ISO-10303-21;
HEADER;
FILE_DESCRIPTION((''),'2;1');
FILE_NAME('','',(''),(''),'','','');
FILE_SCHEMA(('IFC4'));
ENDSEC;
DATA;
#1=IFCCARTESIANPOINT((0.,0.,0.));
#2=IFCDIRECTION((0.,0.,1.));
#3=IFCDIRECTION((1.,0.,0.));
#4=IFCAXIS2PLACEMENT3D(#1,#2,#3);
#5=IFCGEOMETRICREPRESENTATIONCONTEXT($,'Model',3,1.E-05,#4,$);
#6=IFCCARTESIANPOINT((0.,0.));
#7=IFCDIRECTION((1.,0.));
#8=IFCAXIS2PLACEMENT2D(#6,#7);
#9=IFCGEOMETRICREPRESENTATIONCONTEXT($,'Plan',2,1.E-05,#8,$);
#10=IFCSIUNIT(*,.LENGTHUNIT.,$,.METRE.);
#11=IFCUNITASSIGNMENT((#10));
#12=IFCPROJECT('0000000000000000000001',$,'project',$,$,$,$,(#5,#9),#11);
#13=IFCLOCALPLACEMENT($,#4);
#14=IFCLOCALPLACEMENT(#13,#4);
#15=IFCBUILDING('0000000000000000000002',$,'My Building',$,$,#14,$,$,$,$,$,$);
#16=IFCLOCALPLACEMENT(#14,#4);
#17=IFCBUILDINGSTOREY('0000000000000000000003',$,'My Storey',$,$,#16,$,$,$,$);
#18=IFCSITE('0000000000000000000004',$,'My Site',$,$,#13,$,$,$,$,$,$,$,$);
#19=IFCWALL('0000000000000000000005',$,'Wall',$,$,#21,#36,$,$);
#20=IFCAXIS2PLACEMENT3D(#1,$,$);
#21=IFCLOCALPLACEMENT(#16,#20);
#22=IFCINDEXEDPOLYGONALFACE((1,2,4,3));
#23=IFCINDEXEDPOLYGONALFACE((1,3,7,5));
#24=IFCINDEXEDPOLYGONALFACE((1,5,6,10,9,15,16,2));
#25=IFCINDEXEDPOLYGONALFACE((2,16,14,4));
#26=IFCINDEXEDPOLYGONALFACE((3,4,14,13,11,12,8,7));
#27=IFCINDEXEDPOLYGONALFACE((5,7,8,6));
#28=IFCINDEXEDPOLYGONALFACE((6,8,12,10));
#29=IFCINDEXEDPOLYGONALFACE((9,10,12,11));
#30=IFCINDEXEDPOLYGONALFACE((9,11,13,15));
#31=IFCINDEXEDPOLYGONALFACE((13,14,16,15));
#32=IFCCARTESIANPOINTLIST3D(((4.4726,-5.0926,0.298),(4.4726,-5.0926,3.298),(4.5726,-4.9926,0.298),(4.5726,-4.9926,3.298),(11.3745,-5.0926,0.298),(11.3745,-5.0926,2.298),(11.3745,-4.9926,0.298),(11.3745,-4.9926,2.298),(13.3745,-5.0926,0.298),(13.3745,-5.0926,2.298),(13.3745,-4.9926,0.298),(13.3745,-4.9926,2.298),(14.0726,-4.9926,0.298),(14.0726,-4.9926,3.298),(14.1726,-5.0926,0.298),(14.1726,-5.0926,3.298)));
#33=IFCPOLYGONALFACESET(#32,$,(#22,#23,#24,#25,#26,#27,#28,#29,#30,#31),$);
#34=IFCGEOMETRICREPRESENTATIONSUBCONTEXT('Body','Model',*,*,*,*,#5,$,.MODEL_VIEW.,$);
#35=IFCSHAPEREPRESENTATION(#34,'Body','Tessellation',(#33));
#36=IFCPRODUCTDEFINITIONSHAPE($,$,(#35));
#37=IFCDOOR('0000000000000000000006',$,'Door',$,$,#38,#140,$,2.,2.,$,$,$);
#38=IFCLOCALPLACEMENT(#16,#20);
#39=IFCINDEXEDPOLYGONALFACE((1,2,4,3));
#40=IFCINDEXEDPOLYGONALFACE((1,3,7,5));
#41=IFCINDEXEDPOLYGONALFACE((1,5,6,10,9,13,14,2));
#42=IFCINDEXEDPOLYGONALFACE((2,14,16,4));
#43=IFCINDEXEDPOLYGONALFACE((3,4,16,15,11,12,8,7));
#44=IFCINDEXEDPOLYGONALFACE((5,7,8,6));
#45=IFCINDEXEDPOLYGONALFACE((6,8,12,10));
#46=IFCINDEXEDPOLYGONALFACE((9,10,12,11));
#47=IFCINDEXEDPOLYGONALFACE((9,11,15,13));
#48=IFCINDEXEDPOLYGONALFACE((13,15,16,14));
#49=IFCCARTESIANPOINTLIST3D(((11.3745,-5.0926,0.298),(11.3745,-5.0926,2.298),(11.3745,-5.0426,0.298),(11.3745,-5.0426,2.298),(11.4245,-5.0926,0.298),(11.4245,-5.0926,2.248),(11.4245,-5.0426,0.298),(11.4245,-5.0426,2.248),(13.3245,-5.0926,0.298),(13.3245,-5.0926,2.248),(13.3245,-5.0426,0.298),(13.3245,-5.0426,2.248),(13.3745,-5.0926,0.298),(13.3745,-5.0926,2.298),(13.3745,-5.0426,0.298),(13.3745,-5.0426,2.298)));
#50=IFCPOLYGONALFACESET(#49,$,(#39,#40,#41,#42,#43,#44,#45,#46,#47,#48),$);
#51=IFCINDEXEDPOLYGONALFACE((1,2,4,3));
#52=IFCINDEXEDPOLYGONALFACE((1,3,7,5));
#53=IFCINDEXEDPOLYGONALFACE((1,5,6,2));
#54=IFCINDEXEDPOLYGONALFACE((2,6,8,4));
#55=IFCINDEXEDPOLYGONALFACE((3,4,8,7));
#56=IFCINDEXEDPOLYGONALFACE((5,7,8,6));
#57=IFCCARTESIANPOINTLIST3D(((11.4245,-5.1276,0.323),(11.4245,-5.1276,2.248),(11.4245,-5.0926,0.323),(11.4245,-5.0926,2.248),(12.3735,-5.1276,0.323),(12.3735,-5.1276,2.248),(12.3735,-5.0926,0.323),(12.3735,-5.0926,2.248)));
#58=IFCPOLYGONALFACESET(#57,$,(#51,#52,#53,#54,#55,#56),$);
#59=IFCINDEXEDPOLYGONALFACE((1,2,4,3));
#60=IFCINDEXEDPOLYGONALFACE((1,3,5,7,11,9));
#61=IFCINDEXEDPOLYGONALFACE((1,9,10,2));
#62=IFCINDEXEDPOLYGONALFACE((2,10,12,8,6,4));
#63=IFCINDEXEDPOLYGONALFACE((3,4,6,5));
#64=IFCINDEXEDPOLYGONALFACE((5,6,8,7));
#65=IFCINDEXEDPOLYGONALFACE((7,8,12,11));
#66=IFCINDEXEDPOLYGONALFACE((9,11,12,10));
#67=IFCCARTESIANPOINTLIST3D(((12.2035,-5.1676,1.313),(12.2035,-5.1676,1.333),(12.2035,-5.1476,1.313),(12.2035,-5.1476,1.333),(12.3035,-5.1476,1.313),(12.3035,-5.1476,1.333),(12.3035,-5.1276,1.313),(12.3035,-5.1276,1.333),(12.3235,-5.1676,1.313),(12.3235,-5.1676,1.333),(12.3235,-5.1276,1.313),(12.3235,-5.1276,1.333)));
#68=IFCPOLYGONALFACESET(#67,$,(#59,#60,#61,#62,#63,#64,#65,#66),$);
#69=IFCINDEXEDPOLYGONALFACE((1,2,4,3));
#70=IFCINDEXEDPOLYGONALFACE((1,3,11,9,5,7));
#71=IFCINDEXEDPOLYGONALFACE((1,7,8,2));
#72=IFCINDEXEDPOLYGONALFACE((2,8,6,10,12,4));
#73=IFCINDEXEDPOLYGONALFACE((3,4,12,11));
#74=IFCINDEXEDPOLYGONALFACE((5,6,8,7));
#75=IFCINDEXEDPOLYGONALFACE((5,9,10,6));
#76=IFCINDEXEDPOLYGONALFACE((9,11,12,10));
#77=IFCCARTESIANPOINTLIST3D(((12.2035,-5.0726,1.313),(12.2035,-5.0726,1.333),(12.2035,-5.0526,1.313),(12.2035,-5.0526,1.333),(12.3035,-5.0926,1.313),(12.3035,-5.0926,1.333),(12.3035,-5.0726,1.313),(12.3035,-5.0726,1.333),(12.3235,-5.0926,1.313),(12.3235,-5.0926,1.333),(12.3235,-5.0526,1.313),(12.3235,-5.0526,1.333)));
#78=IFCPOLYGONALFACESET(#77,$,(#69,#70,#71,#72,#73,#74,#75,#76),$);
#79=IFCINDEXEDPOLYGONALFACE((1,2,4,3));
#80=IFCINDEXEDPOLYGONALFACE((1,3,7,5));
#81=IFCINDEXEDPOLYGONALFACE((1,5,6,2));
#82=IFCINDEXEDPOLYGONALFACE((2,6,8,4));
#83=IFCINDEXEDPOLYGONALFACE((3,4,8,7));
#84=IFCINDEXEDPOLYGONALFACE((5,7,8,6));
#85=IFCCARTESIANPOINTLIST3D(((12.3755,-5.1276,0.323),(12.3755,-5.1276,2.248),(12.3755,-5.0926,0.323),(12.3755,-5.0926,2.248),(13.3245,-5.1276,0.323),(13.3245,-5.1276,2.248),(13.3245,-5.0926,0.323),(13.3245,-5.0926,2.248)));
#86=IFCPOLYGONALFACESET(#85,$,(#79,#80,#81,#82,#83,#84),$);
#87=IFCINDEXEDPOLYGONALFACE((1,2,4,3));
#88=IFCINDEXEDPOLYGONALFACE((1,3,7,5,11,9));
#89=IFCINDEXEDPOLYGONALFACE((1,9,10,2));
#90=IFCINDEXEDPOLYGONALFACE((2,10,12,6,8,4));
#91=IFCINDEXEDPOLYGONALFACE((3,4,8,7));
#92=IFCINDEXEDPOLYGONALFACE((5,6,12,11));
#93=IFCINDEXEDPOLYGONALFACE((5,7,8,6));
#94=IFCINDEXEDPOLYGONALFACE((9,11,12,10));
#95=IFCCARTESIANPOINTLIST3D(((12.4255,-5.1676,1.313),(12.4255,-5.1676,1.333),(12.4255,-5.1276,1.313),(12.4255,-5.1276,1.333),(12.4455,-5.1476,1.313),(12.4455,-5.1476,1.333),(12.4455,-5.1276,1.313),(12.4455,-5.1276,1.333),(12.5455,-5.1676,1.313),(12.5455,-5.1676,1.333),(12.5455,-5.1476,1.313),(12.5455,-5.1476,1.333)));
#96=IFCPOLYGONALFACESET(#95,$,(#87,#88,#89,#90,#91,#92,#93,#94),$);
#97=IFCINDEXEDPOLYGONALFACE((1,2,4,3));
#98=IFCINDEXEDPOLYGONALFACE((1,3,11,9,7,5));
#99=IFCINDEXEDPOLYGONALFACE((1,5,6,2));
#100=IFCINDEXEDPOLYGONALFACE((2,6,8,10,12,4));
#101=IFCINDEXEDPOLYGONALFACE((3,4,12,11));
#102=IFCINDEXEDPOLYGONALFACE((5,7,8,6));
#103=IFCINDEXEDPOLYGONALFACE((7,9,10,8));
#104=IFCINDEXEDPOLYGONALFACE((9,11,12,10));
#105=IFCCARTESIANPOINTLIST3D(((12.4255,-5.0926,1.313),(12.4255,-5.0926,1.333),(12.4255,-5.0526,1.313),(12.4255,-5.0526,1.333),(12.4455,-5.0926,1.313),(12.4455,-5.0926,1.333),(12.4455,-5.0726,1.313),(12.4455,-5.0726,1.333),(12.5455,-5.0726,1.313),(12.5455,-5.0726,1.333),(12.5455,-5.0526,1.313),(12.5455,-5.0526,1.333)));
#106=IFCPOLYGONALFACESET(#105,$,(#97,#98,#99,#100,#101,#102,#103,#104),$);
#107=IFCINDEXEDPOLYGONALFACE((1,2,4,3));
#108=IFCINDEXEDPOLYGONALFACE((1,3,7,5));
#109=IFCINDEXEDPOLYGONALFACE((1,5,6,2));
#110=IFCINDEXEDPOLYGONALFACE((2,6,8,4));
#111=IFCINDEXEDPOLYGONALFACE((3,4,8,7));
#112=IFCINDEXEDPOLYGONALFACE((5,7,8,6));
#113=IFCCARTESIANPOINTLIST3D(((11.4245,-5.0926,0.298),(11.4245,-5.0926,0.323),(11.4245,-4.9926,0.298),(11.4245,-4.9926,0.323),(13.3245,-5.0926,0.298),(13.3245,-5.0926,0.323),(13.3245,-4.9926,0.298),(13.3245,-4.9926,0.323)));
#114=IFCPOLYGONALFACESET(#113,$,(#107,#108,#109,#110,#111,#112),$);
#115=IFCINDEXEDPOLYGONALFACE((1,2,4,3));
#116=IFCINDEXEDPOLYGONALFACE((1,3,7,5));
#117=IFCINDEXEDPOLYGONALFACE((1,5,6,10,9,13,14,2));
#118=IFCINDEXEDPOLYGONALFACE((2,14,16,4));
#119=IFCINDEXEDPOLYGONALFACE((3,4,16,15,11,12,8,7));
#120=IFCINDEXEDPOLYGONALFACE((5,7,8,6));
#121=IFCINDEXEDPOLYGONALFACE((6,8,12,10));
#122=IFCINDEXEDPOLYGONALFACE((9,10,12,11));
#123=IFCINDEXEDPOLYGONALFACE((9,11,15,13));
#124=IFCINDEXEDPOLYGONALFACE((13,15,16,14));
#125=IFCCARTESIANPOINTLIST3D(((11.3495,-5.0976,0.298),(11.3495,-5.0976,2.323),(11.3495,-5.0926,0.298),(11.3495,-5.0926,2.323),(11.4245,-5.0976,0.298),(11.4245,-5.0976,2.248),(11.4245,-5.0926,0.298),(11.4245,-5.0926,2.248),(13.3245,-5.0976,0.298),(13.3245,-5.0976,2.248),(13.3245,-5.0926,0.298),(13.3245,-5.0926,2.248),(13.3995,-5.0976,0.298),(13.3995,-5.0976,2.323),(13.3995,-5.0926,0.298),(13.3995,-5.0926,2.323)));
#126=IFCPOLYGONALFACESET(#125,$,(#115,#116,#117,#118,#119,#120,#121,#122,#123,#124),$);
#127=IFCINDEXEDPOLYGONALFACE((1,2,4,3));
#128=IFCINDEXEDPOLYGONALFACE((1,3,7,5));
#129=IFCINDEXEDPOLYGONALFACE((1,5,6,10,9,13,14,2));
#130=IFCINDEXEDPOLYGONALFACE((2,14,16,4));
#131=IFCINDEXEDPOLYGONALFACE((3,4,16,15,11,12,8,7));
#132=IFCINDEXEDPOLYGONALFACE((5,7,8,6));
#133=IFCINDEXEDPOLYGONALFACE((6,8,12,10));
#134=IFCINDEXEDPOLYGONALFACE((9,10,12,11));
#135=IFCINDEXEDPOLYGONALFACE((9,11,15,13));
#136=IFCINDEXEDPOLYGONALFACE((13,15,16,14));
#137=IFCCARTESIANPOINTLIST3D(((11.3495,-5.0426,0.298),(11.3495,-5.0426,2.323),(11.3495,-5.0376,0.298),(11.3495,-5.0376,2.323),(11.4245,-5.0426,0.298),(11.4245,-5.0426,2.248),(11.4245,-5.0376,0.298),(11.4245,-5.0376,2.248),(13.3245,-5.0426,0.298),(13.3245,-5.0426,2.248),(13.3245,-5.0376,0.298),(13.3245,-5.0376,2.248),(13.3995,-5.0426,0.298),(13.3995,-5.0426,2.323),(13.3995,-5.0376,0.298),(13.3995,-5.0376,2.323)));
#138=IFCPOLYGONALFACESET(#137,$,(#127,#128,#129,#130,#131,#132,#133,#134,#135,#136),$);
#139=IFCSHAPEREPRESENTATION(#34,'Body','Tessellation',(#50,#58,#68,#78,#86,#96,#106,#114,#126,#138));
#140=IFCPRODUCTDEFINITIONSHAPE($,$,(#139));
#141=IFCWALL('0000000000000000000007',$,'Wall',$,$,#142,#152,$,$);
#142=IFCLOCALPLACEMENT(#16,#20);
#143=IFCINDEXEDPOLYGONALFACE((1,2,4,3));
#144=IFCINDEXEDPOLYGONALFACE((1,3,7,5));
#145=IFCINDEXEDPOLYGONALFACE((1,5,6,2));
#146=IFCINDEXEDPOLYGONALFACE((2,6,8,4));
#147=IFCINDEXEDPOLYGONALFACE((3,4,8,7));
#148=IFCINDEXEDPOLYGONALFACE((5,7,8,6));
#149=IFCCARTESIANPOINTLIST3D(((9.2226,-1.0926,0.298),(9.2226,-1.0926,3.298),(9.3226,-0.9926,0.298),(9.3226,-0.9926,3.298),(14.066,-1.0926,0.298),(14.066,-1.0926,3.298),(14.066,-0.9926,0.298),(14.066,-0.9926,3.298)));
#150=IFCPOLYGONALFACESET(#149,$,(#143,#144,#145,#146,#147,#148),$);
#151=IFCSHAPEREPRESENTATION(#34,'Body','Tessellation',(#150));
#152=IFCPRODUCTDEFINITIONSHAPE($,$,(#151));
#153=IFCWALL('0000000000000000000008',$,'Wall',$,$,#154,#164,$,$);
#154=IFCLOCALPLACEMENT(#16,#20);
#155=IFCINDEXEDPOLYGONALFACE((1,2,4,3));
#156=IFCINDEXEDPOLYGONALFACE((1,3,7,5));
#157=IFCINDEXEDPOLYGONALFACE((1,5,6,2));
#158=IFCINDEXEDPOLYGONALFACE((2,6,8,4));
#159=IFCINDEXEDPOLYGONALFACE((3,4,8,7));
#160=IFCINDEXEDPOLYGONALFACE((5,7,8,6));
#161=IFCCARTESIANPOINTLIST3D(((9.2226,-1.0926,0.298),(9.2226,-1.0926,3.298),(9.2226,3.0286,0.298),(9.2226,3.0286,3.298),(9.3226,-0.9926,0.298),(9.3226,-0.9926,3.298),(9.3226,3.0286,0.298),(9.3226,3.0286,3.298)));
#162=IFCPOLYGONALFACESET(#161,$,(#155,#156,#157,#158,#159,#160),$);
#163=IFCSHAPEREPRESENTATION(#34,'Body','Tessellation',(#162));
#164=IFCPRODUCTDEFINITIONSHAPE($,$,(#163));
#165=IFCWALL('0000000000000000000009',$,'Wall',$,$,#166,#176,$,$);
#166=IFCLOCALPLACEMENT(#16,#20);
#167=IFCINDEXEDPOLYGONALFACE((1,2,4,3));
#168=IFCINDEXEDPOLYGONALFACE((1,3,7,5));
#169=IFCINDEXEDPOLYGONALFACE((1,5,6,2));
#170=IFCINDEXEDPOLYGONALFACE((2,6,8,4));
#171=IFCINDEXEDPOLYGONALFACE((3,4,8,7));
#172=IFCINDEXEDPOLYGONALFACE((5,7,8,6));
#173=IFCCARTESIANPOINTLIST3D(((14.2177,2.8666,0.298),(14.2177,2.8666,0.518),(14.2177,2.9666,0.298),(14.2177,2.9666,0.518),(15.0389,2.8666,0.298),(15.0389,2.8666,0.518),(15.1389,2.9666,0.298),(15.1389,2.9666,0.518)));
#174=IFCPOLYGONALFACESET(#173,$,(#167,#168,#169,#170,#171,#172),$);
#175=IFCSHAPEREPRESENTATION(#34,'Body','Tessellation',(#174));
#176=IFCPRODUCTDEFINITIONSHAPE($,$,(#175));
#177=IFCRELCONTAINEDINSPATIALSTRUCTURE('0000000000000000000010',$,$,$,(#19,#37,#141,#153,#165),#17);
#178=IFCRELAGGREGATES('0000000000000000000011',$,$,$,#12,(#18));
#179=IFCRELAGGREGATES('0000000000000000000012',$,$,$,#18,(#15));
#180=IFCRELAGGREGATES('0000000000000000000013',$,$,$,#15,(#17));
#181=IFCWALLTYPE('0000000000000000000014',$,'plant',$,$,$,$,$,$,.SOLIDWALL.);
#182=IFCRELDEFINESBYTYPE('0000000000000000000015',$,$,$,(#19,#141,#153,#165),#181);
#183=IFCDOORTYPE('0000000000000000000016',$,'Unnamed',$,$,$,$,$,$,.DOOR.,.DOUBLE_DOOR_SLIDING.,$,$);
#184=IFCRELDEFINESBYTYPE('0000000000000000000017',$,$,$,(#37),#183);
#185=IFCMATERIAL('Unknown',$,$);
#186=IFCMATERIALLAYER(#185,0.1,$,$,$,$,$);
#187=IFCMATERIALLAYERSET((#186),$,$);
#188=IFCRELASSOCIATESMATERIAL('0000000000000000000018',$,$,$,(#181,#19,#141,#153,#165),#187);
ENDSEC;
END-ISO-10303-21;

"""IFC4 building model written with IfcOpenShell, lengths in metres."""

from ifc_helpers import new_model, entity, si_unit, frame, origin_with_axes, origin_2d_with_axis, place, context, subcontext, project, spatial, line, indexed_curve, outline, extrude, shape, source, transform, mapped, material, layer, layer_set, layer_usage, type_object, type_shapes, element, fill, save


model = new_model("IFC4")

# Units and contexts
model_context = context("Model", 3, precision=1e-05, world=origin_with_axes())
plan_context = context("Plan", 2, precision=1e-05, world=origin_2d_with_axis())
body_context_1 = subcontext(model_context, "Body", "Model", "MODEL_VIEW")
body_context_2 = subcontext(plan_context, "Body", "Plan", "PLAN_VIEW")
ifc_project = project(units=[si_unit("LENGTHUNIT", "METRE")], contexts=[model_context, plan_context])

# Site, building, storey
site_placement = place(None, origin_with_axes())
site = spatial("IfcSite", under=ifc_project, at=site_placement, Name="My Site")
building_placement = place(site_placement, origin_with_axes())
building = spatial("IfcBuilding", under=site, at=building_placement, Name="My Building")
storey_placement = place(building_placement, origin_with_axes())
storey = spatial("IfcBuildingStorey", under=building, at=storey_placement, Name="My Storey")

# Shared definitions
ifc_material = material(Name="Unknown")

# Shared definitions
ifc_layer_1 = layer(ifc_material, 0.1)
ifc_layer_set_1 = layer_set([ifc_layer_1])
wall_type = type_object("IfcWallType", Name="plant", PredefinedType="SOLIDWALL", material=ifc_layer_set_1)

# Wall, opening, door
ifc_layer_usage_1 = layer_usage(ifc_layer_set_1, "AXIS2", "POSITIVE", 0.0)
wall_1_placement = place(storey_placement, frame((14.0726, -4.9926, 0.298), z_axis=(0.0, 0.0, 1.0), x_axis=(-1.0, 0.0, 0.0)))
wall_1 = element("IfcWall", 1, at=wall_1_placement, inside=storey, type_object=wall_type, material=ifc_layer_usage_1, Name="Wall", context=body_context_1, shape_type="SweptSolid", body=[
    extrude(outline(indexed_curve([(0.0, 0.0), (-0.1, 0.1), (9.6, 0.1), (9.5, 0.0)], segments=[line(1, 2, 3, 4, 1)])), origin_with_axes(), (0.0, 0.0, 1.0), 3.0),
])
shared_shape_1 = source(origin_with_axes(), body_context_1, "Body", "SweptSolid", [
    extrude(outline(indexed_curve([(0.0, 0.0), (2.0, 0.0), (2.0, 2.0), (0.0, 2.0)], segments=[line(1, 2, 3, 4, 1)])), frame((0.0, -0.6, 0.0), z_axis=(0.0, -1.0, 0.0), x_axis=(1.0, 0.0, 0.0)), (0.0, 0.0, -1.0), 1.2),
])
opening_placement = place(wall_1_placement, frame((2.6982, 0.1, 0.0), z_axis=(0.0, 0.0, 1.0), x_axis=(-1.0, 0.0, 0.0)))
opening = element("IfcOpeningElement", 2, at=opening_placement, cuts=wall_1, PredefinedType="OPENING", context=body_context_1, shape_type="MappedRepresentation", body=[
    mapped(shared_shape_1, transform((0.0, 0.0, 0.0), x_axis=(1.0, 0.0, 0.0), y_axis=(0.0, 1.0, 0.0), z_axis=(0.0, 0.0, 1.0), scale=1.0)),
])
door_type = type_object("IfcDoorType", Name="Unnamed", OperationType="DOUBLE_DOOR_SLIDING", PredefinedType="DOOR")
shared_shape_2 = source(origin_with_axes(), body_context_1, "Body", "SweptSolid", [
    extrude(outline(indexed_curve([(0.0, 0.0), (0.0, 2.0), (2.0, 2.0), (2.0, 0.0), (1.95, 0.0), (1.95, 1.95), (0.05, 1.95), (0.05, 0.0)], segments=[line(1, 2, 3, 4, 5, 6, 7, 8, 1)])), frame((0.0, 0.0, 0.0), z_axis=(0.0, -1.0, 0.0), x_axis=(1.0, 0.0, 0.0)), (0.0, 0.0, -1.0), 0.05),
    extrude(outline(indexed_curve([(0.0, 0.035), (0.949, 0.035), (0.949, 0.0), (0.0, 0.0), (0.0, 0.035)])), frame((0.05, -0.035, 0.025), z_axis=(0.0, 0.0, 1.0), x_axis=(1.0, 0.0, 0.0)), (0.0, 0.0, 1.0), 1.925),
    extrude(outline(indexed_curve([(0.0, 0.0), (0.0, -0.04), (-0.12, -0.04), (-0.12, -0.02), (-0.02, -0.02), (-0.02, 0.0)], segments=[line(1, 2, 3, 4, 5, 6, 1)])), frame((0.949, -0.035, 1.015), z_axis=(0.0, 0.0, 1.0), x_axis=(1.0, 0.0, 0.0)), (0.0, 0.0, 1.0), 0.02),
    extrude(outline(indexed_curve([(0.0, 0.0), (0.0, 0.04), (-0.12, 0.04), (-0.12, 0.02), (-0.02, 0.02), (-0.02, 0.0)], segments=[line(1, 2, 3, 4, 5, 6, 1)])), frame((0.949, 0.0, 1.015), z_axis=(0.0, 0.0, 1.0), x_axis=(1.0, 0.0, 0.0)), (0.0, 0.0, 1.0), 0.02),
    extrude(outline(indexed_curve([(0.0, 0.0), (-0.949, 0.0), (-0.949, 0.035), (0.0, 0.035)], segments=[line(1, 2, 3, 4, 1)])), frame((1.95, -0.035, 0.025), z_axis=(0.0, 0.0, 1.0), x_axis=(1.0, 0.0, 0.0)), (0.0, 0.0, 1.0), 1.925),
    extrude(outline(indexed_curve([(0.0, 0.0), (0.0, -0.04), (0.12, -0.04), (0.12, -0.02), (0.02, -0.02), (0.02, 0.0)], segments=[line(1, 2, 3, 4, 5, 6, 1)])), frame((1.051, -0.035, 1.015), z_axis=(0.0, 0.0, 1.0), x_axis=(1.0, 0.0, 0.0)), (0.0, 0.0, 1.0), 0.02),
    extrude(outline(indexed_curve([(0.0, 0.0), (0.0, 0.04), (0.12, 0.04), (0.12, 0.02), (0.02, 0.02), (0.02, 0.0)], segments=[line(1, 2, 3, 4, 5, 6, 1)])), frame((1.051, 0.0, 1.015), z_axis=(0.0, 0.0, 1.0), x_axis=(1.0, 0.0, 0.0)), (0.0, 0.0, 1.0), 0.02),
    extrude(outline(indexed_curve([(0.0, 0.0), (1.9, 0.0), (1.9, 0.1), (0.0, 0.1)], segments=[line(1, 2, 3, 4, 1)])), frame((0.05, 0.0, 0.0), z_axis=(0.0, 0.0, 1.0), x_axis=(1.0, 0.0, 0.0)), (0.0, 0.0, 1.0), 0.025),
    extrude(outline(indexed_curve([(0.0, 0.0), (0.0, 2.025), (2.05, 2.025), (2.05, 0.0), (1.975, 0.0), (1.975, 1.95), (0.075, 1.95), (0.075, 0.0)], segments=[line(1, 2, 3, 4, 5, 6, 7, 8, 1)])), frame((-0.025, -0.005, 0.0), z_axis=(0.0, -1.0, 0.0), x_axis=(1.0, 0.0, 0.0)), (0.0, 0.0, -1.0), 0.005),
    extrude(outline(indexed_curve([(0.0, 0.0), (0.0, 2.025), (2.05, 2.025), (2.05, 0.0), (1.975, 0.0), (1.975, 1.95), (0.075, 1.95), (0.075, 0.0)], segments=[line(1, 2, 3, 4, 5, 6, 7, 8, 1)])), frame((-0.025, 0.05, 0.0), z_axis=(0.0, -1.0, 0.0), x_axis=(1.0, 0.0, 0.0)), (0.0, 0.0, -1.0), 0.005),
])
shared_shape_3 = source(origin_with_axes(), body_context_2, "Body", "Curve2D", [
    entity("IfcIndexedPolyCurve", entity("IfcCartesianPointList2D", [[0.0, 0.0], [0.05, 0.0], [0.05, 0.05], [0.0, 0.05]]), [entity("IfcLineIndex", [1, 2, 3, 4, 1])]),
    entity("IfcIndexedPolyCurve", entity("IfcCartesianPointList2D", [[2.0, 0.0], [1.95, 0.0], [1.95, 0.05], [2.0, 0.05]]), [entity("IfcLineIndex", [1, 2, 3, 4, 1])]),
    entity("IfcIndexedPolyCurve", entity("IfcCartesianPointList2D", [[-0.425, -0.035], [0.525, -0.035], [0.525, 0.0], [-0.425, 0.0]]), [entity("IfcLineIndex", [1, 2, 3, 4, 1])]),
    entity("IfcIndexedPolyCurve", entity("IfcCartesianPointList2D", [[2.425, -0.035], [1.475, -0.035], [1.475, 0.0], [2.425, 0.0]]), [entity("IfcLineIndex", [1, 2, 3, 4, 1])]),
])
type_shapes(door_type, [shared_shape_2, shared_shape_3])
door_placement = place(opening_placement, frame((0.0, 0.0, 0.0), z_axis=(0.0, 0.0, 1.0), x_axis=(1.0, 0.0, 0.0)))
door = element("IfcDoor", 3, at=door_placement, inside=storey, type_object=door_type, Name="Door", OverallHeight=2.0, OverallWidth=2.0, shapes=[
    shape(body_context_1, "Body", "MappedRepresentation", [mapped(shared_shape_2, transform((0.0, 0.0, 0.0), x_axis=(1.0, 0.0, 0.0), y_axis=(0.0, 1.0, 0.0), z_axis=(0.0, 0.0, 1.0), scale=1.0))]),
    shape(body_context_2, "Body", "MappedRepresentation", [mapped(shared_shape_3, transform((0.0, 0.0, 0.0), x_axis=(1.0, 0.0, 0.0), y_axis=(0.0, 1.0, 0.0), z_axis=(0.0, 0.0, 1.0), scale=1.0))]),
])
fill(opening, door)

# Walls
ifc_layer_usage_2 = layer_usage(ifc_layer_set_1, "AXIS2", "POSITIVE", 0.0)
wall_2_placement = place(storey_placement, frame((14.066, -0.9926, 0.298), z_axis=(0.0, 0.0, 1.0), x_axis=(-1.0, 0.0, 0.0)))
element("IfcWall", 4, at=wall_2_placement, inside=storey, type_object=wall_type, material=ifc_layer_usage_2, Name="Wall", context=body_context_1, shape_type="SweptSolid", body=[
    extrude(outline(indexed_curve([(0.0, 0.0), (0.0, 0.1), (4.8434, 0.1), (4.7434, 0.0)], segments=[line(1, 2, 3, 4, 1)])), origin_with_axes(), (0.0, 0.0, 1.0), 3.0),
])
ifc_layer_usage_3 = layer_usage(ifc_layer_set_1, "AXIS2", "POSITIVE", 0.0)
wall_3_placement = place(storey_placement, frame((9.3226, -0.9926, 0.298), z_axis=(0.0, 0.0, 1.0), x_axis=(0.0, 1.0, 0.0)))
element("IfcWall", 5, at=wall_3_placement, inside=storey, type_object=wall_type, material=ifc_layer_usage_3, Name="Wall", context=body_context_1, shape_type="SweptSolid", body=[
    extrude(outline(indexed_curve([(0.0, 0.0), (-0.1, 0.1), (4.0213, 0.1), (4.0213, 0.0)], segments=[line(1, 2, 3, 4, 1)])), origin_with_axes(), (0.0, 0.0, 1.0), 3.0),
])
ifc_layer_usage_4 = layer_usage(ifc_layer_set_1, "AXIS2", "POSITIVE", 0.0)
wall_4_placement = place(storey_placement, frame((14.2177, 2.8666, 0.298), z_axis=(0.0, 0.0, 1.0), x_axis=(1.0, 0.0, 0.0)))
element("IfcWall", 6, at=wall_4_placement, inside=storey, type_object=wall_type, material=ifc_layer_usage_4, Name="Wall", context=body_context_1, shape_type="SweptSolid", body=[
    extrude(outline(indexed_curve([(0.0, 0.0), (0.0, 0.1), (0.9212, 0.1), (0.8212, 0.0)], segments=[line(1, 2, 3, 4, 1)])), origin_with_axes(), (0.0, 0.0, 1.0), 0.22),
])

save(model, "model.ifc")
